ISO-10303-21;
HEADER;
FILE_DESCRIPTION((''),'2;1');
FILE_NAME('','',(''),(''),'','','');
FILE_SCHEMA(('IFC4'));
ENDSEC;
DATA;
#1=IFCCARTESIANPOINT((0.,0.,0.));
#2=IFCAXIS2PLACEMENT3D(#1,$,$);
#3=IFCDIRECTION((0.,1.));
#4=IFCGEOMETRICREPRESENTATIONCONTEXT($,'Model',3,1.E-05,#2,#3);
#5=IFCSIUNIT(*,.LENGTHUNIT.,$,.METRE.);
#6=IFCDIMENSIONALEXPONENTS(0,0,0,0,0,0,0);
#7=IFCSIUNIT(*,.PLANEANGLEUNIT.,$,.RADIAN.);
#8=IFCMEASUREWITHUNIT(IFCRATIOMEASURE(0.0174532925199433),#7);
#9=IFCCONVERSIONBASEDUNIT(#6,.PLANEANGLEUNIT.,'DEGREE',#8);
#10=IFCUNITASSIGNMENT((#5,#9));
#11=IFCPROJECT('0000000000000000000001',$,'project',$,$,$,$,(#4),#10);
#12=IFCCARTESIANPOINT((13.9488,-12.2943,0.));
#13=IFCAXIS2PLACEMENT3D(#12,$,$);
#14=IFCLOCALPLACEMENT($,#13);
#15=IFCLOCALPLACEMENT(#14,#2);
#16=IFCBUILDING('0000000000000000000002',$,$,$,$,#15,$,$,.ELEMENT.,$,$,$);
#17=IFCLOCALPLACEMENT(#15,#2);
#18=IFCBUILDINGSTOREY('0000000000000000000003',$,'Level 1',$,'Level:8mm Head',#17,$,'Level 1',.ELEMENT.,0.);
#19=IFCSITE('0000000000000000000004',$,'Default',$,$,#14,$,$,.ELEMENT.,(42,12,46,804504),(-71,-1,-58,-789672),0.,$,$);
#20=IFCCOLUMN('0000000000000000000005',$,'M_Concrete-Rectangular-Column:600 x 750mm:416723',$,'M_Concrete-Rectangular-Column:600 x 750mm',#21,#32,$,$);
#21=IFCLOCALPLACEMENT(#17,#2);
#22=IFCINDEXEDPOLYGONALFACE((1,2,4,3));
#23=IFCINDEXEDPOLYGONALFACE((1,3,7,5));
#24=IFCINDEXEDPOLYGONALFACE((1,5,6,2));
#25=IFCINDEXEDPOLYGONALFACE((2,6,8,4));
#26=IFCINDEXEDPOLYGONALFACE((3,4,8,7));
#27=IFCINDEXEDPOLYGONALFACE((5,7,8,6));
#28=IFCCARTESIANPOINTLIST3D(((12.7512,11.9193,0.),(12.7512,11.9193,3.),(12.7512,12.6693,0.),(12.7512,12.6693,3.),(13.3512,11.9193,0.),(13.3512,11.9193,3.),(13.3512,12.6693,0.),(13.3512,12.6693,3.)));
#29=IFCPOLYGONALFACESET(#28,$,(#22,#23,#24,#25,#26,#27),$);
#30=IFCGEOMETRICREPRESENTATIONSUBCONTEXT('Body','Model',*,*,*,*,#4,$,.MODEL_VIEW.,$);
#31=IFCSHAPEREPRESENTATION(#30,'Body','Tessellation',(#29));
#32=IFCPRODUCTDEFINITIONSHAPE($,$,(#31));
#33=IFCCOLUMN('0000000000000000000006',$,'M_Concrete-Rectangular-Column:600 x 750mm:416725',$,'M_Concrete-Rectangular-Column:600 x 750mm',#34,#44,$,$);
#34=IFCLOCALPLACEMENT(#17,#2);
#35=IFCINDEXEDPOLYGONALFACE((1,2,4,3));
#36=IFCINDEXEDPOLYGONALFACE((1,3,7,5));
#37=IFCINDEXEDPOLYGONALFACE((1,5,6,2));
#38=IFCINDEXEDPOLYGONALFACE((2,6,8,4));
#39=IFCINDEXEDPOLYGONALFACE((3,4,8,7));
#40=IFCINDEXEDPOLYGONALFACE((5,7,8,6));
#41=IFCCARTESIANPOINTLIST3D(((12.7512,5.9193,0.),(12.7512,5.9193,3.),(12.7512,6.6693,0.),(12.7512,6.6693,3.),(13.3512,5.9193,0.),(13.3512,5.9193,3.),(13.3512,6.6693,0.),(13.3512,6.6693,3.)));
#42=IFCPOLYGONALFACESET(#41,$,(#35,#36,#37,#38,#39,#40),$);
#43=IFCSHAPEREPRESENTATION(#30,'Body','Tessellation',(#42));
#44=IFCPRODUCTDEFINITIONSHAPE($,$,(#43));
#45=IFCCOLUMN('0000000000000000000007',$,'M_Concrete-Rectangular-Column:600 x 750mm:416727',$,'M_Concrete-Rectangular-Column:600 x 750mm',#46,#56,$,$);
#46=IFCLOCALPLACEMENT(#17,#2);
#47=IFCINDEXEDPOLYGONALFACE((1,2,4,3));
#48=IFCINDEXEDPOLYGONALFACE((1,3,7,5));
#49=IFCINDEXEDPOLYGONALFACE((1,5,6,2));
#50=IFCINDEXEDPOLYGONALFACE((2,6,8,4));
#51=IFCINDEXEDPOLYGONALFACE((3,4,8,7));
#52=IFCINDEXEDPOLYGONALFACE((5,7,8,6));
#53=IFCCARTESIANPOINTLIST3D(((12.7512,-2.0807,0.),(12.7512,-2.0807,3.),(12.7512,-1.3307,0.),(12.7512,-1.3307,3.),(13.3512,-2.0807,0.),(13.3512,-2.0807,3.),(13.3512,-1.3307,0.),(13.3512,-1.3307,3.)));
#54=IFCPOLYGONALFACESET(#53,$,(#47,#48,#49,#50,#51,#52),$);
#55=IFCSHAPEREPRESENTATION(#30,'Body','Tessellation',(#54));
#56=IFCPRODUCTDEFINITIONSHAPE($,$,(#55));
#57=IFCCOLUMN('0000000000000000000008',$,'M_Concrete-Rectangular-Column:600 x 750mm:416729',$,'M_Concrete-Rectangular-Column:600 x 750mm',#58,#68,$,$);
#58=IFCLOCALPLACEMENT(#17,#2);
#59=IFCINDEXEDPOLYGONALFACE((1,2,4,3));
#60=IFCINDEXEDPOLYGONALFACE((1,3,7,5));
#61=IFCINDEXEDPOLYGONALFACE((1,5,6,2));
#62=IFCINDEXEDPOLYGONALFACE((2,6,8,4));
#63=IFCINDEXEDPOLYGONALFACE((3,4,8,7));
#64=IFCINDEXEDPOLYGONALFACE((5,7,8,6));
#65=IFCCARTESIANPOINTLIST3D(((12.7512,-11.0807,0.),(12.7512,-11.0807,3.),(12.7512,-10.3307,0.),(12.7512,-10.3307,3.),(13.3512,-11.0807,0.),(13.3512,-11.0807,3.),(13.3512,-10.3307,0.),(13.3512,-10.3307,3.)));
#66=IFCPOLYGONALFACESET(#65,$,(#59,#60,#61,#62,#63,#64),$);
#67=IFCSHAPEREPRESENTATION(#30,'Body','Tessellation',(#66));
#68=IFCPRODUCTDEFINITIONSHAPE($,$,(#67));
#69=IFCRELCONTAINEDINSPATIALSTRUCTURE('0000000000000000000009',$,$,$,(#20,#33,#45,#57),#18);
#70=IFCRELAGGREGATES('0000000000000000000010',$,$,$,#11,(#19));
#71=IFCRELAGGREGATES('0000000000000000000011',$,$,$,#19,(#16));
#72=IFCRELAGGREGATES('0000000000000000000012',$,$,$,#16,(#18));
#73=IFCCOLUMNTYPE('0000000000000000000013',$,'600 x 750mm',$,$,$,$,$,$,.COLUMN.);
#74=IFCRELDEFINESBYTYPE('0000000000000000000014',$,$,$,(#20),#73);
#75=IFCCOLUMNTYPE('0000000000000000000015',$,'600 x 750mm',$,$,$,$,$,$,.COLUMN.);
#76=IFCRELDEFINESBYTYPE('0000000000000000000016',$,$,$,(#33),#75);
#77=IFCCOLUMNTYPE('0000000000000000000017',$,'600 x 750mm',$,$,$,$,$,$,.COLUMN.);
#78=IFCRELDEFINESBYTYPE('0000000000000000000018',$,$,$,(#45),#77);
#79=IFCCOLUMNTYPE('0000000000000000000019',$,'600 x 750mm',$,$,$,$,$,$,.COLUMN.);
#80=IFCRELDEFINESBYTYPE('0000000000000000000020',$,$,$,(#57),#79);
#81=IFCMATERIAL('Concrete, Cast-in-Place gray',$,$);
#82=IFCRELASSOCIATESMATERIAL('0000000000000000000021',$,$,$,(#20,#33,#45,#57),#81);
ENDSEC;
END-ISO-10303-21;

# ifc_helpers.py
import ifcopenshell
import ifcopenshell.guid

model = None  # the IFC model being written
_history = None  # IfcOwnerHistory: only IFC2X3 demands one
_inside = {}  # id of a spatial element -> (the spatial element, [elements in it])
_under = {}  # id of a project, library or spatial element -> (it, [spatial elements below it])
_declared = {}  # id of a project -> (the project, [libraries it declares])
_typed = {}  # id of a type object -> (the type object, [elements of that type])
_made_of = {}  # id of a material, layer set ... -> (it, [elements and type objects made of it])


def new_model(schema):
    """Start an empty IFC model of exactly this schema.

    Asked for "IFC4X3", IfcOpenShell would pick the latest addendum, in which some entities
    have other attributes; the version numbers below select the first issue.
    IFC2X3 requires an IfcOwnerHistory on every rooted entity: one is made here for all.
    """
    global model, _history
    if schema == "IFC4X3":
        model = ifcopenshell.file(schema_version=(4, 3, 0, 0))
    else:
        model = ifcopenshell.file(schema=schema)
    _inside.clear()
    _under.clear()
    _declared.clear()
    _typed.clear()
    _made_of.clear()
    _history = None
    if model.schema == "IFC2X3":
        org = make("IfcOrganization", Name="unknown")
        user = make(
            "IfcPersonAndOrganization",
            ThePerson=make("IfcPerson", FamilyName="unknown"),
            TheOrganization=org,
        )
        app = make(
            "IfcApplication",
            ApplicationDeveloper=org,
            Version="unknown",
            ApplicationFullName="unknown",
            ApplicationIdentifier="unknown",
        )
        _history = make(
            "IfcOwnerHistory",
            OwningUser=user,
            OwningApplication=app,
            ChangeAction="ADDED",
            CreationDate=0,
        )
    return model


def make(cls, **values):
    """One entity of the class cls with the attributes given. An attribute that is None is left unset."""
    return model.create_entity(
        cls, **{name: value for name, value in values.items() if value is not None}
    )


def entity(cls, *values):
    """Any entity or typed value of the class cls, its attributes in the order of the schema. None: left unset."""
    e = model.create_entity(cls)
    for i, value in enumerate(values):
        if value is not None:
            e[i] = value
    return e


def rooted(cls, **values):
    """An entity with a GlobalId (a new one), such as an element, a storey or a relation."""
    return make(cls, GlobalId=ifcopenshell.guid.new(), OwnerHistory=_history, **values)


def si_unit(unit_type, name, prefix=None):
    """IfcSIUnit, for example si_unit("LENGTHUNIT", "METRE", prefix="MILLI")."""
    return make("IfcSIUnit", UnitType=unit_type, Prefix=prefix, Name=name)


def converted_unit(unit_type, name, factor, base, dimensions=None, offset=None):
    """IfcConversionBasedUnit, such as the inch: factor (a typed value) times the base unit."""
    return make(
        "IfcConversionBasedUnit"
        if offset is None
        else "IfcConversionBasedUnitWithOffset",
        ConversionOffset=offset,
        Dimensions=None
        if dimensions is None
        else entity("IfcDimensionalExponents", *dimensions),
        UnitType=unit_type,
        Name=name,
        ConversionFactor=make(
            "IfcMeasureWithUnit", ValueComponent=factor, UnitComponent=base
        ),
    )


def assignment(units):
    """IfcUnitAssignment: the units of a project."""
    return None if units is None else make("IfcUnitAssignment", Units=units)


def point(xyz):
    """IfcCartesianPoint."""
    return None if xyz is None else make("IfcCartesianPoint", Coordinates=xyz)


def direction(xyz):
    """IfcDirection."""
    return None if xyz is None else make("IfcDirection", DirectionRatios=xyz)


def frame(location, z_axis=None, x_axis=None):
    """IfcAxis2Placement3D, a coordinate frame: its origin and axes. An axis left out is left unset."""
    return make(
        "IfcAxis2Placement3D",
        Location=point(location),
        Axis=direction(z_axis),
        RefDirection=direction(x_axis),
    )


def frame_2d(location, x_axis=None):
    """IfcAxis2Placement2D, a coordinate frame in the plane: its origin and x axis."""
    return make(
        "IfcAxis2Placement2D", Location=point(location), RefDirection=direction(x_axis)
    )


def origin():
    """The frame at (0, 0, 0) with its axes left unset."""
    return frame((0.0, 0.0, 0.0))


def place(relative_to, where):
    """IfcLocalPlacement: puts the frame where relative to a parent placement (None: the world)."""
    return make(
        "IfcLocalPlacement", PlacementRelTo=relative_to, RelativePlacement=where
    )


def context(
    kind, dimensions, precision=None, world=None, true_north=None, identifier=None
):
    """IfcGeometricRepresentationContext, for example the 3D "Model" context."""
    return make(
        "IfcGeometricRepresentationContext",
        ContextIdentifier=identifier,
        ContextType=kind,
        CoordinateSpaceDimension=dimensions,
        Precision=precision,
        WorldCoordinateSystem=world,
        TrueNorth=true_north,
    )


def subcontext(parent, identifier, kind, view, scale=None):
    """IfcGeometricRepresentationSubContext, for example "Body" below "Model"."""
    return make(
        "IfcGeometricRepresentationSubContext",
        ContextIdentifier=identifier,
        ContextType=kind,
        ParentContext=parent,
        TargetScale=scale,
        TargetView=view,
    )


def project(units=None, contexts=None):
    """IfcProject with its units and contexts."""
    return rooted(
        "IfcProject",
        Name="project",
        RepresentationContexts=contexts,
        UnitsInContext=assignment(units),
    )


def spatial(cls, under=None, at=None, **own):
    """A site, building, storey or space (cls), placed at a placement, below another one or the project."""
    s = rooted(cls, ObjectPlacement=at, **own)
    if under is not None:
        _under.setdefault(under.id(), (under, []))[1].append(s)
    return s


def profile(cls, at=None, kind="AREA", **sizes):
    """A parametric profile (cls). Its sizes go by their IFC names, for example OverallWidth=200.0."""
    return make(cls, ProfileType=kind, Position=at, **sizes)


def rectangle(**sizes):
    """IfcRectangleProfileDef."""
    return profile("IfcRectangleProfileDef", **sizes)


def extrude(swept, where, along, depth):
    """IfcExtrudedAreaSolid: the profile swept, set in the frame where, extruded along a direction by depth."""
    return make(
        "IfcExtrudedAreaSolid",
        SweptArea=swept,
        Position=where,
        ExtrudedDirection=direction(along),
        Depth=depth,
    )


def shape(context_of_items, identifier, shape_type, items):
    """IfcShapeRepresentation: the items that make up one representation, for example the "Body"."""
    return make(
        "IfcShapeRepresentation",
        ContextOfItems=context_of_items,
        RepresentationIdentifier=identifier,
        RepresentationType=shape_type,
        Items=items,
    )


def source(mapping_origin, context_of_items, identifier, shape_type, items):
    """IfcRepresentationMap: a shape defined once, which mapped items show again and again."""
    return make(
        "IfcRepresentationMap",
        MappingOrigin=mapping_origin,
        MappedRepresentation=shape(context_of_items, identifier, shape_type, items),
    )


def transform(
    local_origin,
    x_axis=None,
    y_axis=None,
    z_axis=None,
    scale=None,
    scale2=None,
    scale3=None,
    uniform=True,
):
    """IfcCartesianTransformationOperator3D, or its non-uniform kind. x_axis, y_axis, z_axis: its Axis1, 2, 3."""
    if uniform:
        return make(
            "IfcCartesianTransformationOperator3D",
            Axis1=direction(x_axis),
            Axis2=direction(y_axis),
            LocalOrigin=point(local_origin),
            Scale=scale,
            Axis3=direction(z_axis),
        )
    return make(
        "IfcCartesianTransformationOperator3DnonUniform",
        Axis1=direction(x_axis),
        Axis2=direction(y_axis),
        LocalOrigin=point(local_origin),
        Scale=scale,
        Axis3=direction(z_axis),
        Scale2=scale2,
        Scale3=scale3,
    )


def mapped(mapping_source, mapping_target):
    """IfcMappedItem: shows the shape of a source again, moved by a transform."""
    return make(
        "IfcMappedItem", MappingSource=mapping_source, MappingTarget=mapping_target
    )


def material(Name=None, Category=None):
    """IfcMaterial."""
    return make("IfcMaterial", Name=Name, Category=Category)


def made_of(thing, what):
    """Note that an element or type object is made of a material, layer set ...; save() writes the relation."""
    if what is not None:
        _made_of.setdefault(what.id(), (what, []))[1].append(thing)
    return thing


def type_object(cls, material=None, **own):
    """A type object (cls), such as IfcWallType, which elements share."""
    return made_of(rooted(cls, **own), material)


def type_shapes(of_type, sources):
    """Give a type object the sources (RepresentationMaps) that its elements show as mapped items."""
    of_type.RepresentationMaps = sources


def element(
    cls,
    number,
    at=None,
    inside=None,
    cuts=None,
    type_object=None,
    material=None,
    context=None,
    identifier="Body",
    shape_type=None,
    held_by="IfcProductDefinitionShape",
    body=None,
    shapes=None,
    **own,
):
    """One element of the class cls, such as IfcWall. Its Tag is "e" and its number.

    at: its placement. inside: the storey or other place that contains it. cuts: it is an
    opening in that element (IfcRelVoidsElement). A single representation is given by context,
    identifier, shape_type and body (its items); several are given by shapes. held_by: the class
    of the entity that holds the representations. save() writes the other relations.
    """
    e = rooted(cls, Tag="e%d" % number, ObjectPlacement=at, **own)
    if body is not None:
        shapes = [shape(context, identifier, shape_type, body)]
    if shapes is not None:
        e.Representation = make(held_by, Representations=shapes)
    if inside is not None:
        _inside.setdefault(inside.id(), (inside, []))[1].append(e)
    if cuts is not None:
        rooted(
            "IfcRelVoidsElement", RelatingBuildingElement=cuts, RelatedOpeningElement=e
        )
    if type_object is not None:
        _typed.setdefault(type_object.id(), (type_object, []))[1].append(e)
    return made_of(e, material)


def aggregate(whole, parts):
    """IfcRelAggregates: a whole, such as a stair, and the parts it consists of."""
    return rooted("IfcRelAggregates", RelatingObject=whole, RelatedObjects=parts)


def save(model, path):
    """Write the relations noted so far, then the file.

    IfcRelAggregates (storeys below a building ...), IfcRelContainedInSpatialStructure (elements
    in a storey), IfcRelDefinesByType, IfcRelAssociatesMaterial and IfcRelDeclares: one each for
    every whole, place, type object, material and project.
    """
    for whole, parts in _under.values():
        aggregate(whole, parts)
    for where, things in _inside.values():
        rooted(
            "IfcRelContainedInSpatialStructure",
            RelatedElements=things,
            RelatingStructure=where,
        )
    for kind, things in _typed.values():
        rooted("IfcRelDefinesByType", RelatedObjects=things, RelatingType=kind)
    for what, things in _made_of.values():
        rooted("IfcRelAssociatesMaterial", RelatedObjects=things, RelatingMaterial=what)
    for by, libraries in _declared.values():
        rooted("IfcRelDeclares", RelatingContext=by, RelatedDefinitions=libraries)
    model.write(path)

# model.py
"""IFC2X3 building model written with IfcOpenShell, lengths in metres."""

from ifc_helpers import new_model, entity, si_unit, converted_unit, direction, frame, frame_2d, origin, place, context, subcontext, project, spatial, rectangle, extrude, source, transform, mapped, material, type_object, type_shapes, element, save


model = new_model("IFC2X3")

# Units and contexts
model_context = context("Model", 3, precision=1e-05, world=origin(), true_north=direction((0.0, 1.0)))
body_context = subcontext(model_context, "Body", "Model", "MODEL_VIEW")
ifc_project = project(units=[si_unit("LENGTHUNIT", "METRE"), converted_unit("PLANEANGLEUNIT", "DEGREE", entity("IfcRatioMeasure", 0.0174532925199433), si_unit("PLANEANGLEUNIT", "RADIAN"), dimensions=[0, 0, 0, 0, 0, 0, 0])], contexts=[model_context])

# Site, building, storey
site_placement = place(None, frame((13.9488, -12.2943, 0.0)))
site = spatial("IfcSite", under=ifc_project, at=site_placement, Name="Default", CompositionType="ELEMENT", RefLatitude=(42, 12, 46, 804504), RefLongitude=(-71, -1, -58, -789672), RefElevation=0.0)
building_placement = place(site_placement, origin())
building = spatial("IfcBuilding", under=site, at=building_placement, CompositionType="ELEMENT")
storey_placement = place(building_placement, origin())
storey = spatial("IfcBuildingStorey", under=building, at=storey_placement, Name="Level 1", ObjectType="Level:8mm Head", LongName="Level 1", CompositionType="ELEMENT", Elevation=0.0)

# Columns
ifc_material = material(Name="Concrete, Cast-in-Place gray")
column_type_1 = type_object("IfcColumnType", Name="600 x 750mm", PredefinedType="COLUMN")
shared_shape_1 = source(origin(), body_context, "Body", "SweptSolid", [
    extrude(rectangle(XDim=0.75, YDim=0.6, at=frame_2d((0.0, 0.0), x_axis=(1.0, 0.0))), frame((13.0512, 12.2943, 0.0), z_axis=(0.0, 0.0, 1.0), x_axis=(0.0, -1.0, 0.0)), (0.0, 0.0, 1.0), 3.0),
])
type_shapes(column_type_1, [shared_shape_1])
column_1_placement = place(storey_placement, origin())
element("IfcColumn", 1, at=column_1_placement, inside=storey, type_object=column_type_1, material=ifc_material, Name="M_Concrete-Rectangular-Column:600 x 750mm:416723", ObjectType="M_Concrete-Rectangular-Column:600 x 750mm", context=body_context, shape_type="MappedRepresentation", body=[
    mapped(shared_shape_1, transform((0.0, 0.0, 0.0), scale=1.0)),
])
column_type_2 = type_object("IfcColumnType", Name="600 x 750mm", PredefinedType="COLUMN")
shared_shape_2 = source(origin(), body_context, "Body", "SweptSolid", [
    extrude(rectangle(XDim=0.75, YDim=0.6, at=frame_2d((0.0, 0.0), x_axis=(1.0, 0.0))), frame((13.0512, 6.2943, 0.0), z_axis=(0.0, 0.0, 1.0), x_axis=(0.0, -1.0, 0.0)), (0.0, 0.0, 1.0), 3.0),
])
type_shapes(column_type_2, [shared_shape_2])
column_2_placement = place(storey_placement, origin())
element("IfcColumn", 2, at=column_2_placement, inside=storey, type_object=column_type_2, material=ifc_material, Name="M_Concrete-Rectangular-Column:600 x 750mm:416725", ObjectType="M_Concrete-Rectangular-Column:600 x 750mm", context=body_context, shape_type="MappedRepresentation", body=[
    mapped(shared_shape_2, transform((0.0, 0.0, 0.0), scale=1.0)),
])
column_type_3 = type_object("IfcColumnType", Name="600 x 750mm", PredefinedType="COLUMN")
shared_shape_3 = source(origin(), body_context, "Body", "SweptSolid", [
    extrude(rectangle(XDim=0.75, YDim=0.6, at=frame_2d((0.0, 0.0), x_axis=(1.0, 0.0))), frame((13.0512, -1.7057, 0.0), z_axis=(0.0, 0.0, 1.0), x_axis=(0.0, -1.0, 0.0)), (0.0, 0.0, 1.0), 3.0),
])
type_shapes(column_type_3, [shared_shape_3])
column_3_placement = place(storey_placement, origin())
element("IfcColumn", 3, at=column_3_placement, inside=storey, type_object=column_type_3, material=ifc_material, Name="M_Concrete-Rectangular-Column:600 x 750mm:416727", ObjectType="M_Concrete-Rectangular-Column:600 x 750mm", context=body_context, shape_type="MappedRepresentation", body=[
    mapped(shared_shape_3, transform((0.0, 0.0, 0.0), scale=1.0)),
])
column_type_4 = type_object("IfcColumnType", Name="600 x 750mm", PredefinedType="COLUMN")
shared_shape_4 = source(origin(), body_context, "Body", "SweptSolid", [
    extrude(rectangle(XDim=0.75, YDim=0.6, at=frame_2d((0.0, 0.0), x_axis=(1.0, 0.0))), frame((13.0512, -10.7057, 0.0), z_axis=(0.0, 0.0, 1.0), x_axis=(0.0, -1.0, 0.0)), (0.0, 0.0, 1.0), 3.0),
])
type_shapes(column_type_4, [shared_shape_4])
column_4_placement = place(storey_placement, origin())
element("IfcColumn", 4, at=column_4_placement, inside=storey, type_object=column_type_4, material=ifc_material, Name="M_Concrete-Rectangular-Column:600 x 750mm:416729", ObjectType="M_Concrete-Rectangular-Column:600 x 750mm", context=body_context, shape_type="MappedRepresentation", body=[
    mapped(shared_shape_4, transform((0.0, 0.0, 0.0), scale=1.0)),
])

save(model, "model.ifc")
